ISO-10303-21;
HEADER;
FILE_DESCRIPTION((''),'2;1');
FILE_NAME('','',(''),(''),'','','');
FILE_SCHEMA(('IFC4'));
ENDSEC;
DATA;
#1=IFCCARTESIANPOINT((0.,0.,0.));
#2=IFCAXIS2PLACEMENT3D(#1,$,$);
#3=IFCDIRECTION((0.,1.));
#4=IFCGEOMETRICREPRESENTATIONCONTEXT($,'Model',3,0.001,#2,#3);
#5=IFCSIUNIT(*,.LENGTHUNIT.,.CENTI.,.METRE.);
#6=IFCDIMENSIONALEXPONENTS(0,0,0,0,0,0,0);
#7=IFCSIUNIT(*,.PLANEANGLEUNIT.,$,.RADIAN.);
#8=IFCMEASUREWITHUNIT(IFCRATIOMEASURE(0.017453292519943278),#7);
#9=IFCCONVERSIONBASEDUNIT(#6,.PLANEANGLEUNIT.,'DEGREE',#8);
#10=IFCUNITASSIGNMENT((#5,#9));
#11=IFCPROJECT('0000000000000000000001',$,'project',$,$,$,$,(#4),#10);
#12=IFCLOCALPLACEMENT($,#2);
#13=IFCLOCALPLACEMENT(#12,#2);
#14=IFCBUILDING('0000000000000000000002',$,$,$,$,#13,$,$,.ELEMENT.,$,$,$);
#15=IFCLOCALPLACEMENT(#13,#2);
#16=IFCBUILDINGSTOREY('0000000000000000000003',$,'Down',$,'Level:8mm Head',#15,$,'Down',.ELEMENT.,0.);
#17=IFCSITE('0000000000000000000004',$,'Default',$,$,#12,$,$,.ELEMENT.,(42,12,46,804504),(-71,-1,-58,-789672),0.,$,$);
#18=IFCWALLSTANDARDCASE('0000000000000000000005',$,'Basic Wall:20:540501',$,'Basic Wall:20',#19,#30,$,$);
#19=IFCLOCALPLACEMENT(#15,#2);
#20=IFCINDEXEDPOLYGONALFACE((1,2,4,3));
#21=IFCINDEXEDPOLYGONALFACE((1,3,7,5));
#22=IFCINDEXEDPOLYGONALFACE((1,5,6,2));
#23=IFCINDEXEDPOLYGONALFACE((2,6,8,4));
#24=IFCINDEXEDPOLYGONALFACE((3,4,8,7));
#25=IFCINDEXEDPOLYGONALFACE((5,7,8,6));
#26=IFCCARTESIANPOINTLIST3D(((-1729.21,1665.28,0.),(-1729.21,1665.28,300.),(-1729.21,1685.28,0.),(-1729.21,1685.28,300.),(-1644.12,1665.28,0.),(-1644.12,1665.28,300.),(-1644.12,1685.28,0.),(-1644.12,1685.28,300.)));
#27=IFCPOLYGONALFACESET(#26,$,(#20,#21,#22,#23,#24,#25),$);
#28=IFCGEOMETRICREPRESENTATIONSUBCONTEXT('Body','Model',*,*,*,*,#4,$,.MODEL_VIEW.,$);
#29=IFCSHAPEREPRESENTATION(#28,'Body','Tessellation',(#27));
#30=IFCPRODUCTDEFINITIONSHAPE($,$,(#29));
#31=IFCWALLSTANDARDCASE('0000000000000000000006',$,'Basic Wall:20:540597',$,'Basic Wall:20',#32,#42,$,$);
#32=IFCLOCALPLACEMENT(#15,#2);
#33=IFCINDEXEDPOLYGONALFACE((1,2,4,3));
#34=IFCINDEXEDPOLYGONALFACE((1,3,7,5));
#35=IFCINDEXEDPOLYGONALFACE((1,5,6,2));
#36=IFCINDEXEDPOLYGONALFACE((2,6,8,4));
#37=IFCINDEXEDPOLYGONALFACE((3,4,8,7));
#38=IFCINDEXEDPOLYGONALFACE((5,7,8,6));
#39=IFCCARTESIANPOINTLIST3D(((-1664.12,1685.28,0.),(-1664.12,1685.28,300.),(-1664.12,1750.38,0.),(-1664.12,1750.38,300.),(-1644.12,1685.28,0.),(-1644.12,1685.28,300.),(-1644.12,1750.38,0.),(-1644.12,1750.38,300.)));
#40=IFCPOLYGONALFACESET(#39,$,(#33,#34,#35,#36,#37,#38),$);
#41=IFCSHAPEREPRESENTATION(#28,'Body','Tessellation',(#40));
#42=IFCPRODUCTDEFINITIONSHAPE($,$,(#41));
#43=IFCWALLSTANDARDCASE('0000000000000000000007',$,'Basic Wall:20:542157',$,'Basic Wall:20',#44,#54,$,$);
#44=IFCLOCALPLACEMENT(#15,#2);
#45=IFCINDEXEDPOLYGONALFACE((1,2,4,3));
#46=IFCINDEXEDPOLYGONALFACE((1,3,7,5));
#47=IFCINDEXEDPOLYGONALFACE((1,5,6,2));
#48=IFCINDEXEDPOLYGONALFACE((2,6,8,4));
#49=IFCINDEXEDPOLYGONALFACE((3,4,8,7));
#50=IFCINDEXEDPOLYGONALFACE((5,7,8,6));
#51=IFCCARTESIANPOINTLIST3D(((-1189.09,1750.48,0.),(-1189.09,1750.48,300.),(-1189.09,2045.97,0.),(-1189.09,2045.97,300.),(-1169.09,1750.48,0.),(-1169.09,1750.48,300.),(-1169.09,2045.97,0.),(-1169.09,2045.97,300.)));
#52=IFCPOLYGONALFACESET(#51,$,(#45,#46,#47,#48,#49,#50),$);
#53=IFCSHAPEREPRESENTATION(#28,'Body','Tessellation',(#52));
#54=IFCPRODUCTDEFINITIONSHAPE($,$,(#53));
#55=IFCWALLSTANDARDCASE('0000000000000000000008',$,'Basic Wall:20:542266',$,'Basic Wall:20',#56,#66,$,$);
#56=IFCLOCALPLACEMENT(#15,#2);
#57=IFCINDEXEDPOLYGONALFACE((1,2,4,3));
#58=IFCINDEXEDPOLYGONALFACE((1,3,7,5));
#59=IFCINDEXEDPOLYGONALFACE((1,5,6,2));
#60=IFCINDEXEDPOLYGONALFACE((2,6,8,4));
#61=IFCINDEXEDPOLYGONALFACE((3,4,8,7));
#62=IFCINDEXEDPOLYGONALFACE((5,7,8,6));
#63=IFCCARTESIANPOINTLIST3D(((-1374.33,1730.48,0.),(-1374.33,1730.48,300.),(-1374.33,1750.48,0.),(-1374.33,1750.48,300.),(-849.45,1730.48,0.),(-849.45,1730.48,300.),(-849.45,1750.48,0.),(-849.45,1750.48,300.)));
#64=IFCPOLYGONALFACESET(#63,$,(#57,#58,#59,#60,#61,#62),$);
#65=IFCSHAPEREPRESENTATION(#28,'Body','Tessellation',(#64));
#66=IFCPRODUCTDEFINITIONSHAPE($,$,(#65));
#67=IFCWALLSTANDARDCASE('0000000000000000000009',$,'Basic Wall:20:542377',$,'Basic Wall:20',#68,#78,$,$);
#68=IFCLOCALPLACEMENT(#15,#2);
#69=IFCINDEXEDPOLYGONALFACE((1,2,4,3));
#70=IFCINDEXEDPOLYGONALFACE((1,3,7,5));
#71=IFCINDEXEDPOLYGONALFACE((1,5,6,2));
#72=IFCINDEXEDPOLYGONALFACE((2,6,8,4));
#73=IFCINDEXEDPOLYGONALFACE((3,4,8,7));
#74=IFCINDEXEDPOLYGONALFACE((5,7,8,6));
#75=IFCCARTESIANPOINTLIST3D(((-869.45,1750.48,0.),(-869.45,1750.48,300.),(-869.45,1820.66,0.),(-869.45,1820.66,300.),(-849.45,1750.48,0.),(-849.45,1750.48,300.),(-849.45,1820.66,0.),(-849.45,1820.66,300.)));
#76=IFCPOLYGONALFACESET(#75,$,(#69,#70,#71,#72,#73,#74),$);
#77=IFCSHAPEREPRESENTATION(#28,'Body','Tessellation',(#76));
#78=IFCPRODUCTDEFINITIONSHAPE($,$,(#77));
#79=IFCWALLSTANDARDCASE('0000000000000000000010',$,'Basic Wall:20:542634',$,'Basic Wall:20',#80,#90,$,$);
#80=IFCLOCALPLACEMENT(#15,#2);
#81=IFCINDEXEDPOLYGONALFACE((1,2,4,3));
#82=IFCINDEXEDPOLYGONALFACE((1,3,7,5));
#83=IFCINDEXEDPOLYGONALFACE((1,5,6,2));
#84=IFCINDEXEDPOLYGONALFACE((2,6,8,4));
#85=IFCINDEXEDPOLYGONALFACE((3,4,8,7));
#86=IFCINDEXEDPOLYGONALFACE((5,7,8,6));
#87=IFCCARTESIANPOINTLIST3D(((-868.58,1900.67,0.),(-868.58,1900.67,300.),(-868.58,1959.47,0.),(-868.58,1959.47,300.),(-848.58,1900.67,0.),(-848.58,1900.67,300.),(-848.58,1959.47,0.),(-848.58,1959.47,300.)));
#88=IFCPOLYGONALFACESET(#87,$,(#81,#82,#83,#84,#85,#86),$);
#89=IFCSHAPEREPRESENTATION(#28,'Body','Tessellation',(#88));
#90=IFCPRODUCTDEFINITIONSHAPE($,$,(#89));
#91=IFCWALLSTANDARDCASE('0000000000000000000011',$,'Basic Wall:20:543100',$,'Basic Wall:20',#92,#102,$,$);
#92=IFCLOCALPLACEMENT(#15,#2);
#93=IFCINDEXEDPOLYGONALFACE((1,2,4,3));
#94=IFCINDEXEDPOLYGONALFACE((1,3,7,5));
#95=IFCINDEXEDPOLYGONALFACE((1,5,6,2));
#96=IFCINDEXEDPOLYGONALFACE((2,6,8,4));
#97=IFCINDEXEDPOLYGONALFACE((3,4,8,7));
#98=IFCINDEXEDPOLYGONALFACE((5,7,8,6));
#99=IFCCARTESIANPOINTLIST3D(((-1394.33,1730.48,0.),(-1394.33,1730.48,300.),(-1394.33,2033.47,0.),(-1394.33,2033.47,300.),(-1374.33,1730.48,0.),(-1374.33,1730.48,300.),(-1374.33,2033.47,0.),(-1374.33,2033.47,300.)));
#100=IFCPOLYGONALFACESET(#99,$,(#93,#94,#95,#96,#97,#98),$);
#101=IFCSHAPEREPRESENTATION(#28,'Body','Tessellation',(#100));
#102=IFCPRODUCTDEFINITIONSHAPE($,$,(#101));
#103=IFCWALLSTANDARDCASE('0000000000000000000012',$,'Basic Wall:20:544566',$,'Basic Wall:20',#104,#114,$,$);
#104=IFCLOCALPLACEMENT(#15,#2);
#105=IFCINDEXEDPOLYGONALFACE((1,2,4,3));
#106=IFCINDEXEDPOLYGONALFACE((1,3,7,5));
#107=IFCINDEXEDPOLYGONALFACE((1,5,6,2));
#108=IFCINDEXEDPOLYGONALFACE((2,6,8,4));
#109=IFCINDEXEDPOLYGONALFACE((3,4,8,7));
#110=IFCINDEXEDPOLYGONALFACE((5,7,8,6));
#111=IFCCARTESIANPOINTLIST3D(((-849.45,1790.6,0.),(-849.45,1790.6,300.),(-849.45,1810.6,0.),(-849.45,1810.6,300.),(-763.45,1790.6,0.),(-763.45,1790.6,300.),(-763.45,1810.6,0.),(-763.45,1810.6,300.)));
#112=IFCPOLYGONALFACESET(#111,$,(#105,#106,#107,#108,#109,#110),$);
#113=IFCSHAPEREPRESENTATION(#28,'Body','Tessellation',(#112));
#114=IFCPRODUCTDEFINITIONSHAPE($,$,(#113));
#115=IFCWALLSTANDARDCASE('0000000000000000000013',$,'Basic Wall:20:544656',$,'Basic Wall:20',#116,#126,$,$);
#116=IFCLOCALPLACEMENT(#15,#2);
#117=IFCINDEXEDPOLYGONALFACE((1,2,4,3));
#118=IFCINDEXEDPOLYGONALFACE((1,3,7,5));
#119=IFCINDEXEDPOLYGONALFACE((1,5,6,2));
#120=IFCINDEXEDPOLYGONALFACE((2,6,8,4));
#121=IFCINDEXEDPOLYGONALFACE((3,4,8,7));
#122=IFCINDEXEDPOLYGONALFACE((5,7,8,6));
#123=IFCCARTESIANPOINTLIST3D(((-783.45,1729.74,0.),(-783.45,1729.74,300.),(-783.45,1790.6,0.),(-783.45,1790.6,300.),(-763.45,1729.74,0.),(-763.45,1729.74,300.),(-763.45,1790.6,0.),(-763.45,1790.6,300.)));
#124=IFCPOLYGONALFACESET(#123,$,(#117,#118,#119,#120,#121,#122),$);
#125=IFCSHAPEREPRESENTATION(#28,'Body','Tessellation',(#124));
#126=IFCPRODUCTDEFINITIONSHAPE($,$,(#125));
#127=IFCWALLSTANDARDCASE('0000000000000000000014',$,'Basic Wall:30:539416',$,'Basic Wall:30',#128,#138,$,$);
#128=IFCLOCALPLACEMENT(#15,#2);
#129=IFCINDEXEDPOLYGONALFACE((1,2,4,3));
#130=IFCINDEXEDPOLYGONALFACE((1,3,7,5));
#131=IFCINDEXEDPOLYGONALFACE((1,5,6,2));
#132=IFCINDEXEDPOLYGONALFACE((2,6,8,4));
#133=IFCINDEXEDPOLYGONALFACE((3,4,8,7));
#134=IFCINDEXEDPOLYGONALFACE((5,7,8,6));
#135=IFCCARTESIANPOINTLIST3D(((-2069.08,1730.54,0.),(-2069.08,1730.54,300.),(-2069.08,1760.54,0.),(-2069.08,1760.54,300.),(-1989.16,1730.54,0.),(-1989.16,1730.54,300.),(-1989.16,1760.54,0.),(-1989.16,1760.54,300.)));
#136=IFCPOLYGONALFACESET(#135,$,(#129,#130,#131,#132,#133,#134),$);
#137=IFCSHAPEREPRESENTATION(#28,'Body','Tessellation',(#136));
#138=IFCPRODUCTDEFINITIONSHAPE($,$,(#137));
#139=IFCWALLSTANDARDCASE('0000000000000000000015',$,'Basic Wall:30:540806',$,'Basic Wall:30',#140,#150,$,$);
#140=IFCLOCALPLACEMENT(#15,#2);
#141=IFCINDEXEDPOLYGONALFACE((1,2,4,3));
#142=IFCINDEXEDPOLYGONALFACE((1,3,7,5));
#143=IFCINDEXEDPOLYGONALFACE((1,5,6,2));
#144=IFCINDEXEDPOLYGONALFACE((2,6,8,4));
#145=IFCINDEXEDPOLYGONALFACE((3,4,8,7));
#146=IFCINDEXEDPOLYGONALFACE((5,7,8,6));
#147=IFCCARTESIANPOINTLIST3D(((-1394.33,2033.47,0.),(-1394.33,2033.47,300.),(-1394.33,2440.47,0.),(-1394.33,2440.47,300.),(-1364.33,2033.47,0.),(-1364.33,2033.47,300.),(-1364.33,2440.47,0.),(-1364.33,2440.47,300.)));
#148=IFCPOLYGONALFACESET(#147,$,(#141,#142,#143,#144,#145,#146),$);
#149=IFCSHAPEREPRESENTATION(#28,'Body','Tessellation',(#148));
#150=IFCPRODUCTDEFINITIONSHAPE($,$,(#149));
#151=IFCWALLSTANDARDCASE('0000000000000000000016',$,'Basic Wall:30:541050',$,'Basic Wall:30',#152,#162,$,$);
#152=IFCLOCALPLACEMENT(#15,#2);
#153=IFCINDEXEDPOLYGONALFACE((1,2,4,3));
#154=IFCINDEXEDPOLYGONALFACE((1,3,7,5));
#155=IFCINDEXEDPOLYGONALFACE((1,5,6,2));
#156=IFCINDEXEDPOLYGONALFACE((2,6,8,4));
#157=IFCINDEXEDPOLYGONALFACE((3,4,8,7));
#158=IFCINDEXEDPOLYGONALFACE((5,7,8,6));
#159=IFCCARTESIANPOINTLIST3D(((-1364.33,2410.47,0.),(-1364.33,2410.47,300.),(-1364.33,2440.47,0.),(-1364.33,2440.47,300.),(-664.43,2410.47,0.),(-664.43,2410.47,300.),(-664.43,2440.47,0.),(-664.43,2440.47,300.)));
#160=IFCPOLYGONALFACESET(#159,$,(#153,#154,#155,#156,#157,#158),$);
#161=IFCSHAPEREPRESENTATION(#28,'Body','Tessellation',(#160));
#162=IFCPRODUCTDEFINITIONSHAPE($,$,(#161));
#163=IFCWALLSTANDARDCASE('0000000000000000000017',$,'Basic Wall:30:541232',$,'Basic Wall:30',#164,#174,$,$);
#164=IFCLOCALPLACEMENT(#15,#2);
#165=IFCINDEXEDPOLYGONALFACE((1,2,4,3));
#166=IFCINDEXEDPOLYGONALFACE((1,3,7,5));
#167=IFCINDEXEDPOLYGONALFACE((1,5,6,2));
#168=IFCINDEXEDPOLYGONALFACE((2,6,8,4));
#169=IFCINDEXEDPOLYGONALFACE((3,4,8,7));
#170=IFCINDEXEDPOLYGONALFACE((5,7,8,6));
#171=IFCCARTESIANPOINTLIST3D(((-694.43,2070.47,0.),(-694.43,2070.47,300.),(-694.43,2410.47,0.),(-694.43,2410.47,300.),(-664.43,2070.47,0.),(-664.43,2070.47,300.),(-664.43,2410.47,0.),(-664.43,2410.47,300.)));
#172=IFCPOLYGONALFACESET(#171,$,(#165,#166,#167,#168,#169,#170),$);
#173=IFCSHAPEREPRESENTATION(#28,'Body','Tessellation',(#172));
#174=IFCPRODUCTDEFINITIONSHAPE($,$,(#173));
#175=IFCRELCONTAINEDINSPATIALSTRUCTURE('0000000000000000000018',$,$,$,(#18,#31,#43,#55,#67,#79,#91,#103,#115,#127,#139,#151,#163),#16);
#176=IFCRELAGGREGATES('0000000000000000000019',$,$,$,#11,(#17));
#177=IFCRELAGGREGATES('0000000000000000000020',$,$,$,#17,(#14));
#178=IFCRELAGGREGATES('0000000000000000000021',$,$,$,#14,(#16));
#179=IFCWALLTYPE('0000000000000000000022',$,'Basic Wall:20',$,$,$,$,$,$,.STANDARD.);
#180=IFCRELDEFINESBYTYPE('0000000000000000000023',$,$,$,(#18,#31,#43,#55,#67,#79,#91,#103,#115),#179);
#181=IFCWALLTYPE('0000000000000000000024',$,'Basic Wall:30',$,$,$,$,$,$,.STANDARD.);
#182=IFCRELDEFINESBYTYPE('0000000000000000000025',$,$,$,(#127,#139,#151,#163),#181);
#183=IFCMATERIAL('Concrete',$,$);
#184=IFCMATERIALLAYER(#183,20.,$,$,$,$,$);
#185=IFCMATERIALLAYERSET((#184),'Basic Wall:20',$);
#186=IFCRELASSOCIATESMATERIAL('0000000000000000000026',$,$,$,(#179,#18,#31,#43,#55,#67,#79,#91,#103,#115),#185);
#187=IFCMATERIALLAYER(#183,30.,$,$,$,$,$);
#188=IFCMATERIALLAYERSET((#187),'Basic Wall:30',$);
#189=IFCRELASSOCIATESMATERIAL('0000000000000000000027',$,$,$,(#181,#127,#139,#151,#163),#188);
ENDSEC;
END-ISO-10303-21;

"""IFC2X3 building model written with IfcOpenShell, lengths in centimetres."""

from ifc_helpers import new_model, entity, si_unit, converted_unit, direction, frame, frame_2d, origin, place, context, subcontext, project, spatial, rectangle, extrude, material, layer, layer_set, layer_usage, type_object, element, save


model = new_model("IFC2X3")

# Units and contexts
model_context = context("Model", 3, precision=0.001, world=origin(), true_north=direction((0.0, 1.0)))
body_context = subcontext(model_context, "Body", "Model", "MODEL_VIEW")
ifc_project = project(units=[si_unit("LENGTHUNIT", "METRE", prefix="CENTI"), converted_unit("PLANEANGLEUNIT", "DEGREE", entity("IfcRatioMeasure", 0.017453292519943278), si_unit("PLANEANGLEUNIT", "RADIAN"), dimensions=[0, 0, 0, 0, 0, 0, 0])], contexts=[model_context])

# Site, building, storey
site_placement = place(None, origin())
site = spatial("IfcSite", under=ifc_project, at=site_placement, Name="Default", CompositionType="ELEMENT", RefLatitude=(42, 12, 46, 804504), RefLongitude=(-71, -1, -58, -789672), RefElevation=0.0)
building_placement = place(site_placement, origin())
building = spatial("IfcBuilding", under=site, at=building_placement, CompositionType="ELEMENT")
storey_placement = place(building_placement, origin())
storey = spatial("IfcBuildingStorey", under=building, at=storey_placement, Name="Down", ObjectType="Level:8mm Head", LongName="Down", CompositionType="ELEMENT", Elevation=0.0)

# Shared definitions
ifc_material = material(Name="Concrete")

# Walls
ifc_layer_1 = layer(ifc_material, 20.0)
ifc_layer_set_1 = layer_set([ifc_layer_1], Name="Basic Wall:20")
wall_type_1 = type_object("IfcWallType", Name="Basic Wall:20", PredefinedType="STANDARD", material=ifc_layer_set_1)
ifc_layer_usage_1 = layer_usage(ifc_layer_set_1, "AXIS2", "POSITIVE", -10.0)
wall_1_placement = place(storey_placement, frame((-1729.21, 1675.28, 0.0)))
element("IfcWallStandardCase", 1, at=wall_1_placement, inside=storey, type_object=wall_type_1, material=ifc_layer_usage_1, Name="Basic Wall:20:540501", ObjectType="Basic Wall:20", context=body_context, shape_type="SweptSolid", body=[
    extrude(rectangle(XDim=85.1, YDim=20.0, at=frame_2d((42.55, 0.0), x_axis=(-1.0, 0.0))), origin(), (0.0, 0.0, 1.0), 300.0),
])
ifc_layer_usage_2 = layer_usage(ifc_layer_set_1, "AXIS2", "POSITIVE", -10.0)
wall_2_placement = place(storey_placement, frame((-1654.12, 1685.28, 0.0), z_axis=(0.0, 0.0, 1.0), x_axis=(0.0, 1.0, 0.0)))
element("IfcWallStandardCase", 2, at=wall_2_placement, inside=storey, type_object=wall_type_1, material=ifc_layer_usage_2, Name="Basic Wall:20:540597", ObjectType="Basic Wall:20", context=body_context, shape_type="SweptSolid", body=[
    extrude(rectangle(XDim=65.1, YDim=20.0, at=frame_2d((32.55, 0.0), x_axis=(-1.0, 0.0))), origin(), (0.0, 0.0, 1.0), 300.0),
])
ifc_layer_usage_3 = layer_usage(ifc_layer_set_1, "AXIS2", "NEGATIVE", 10.0)
wall_3_placement = place(storey_placement, frame((-1179.09, 2045.97, 0.0), z_axis=(0.0, 0.0, 1.0), x_axis=(0.0, -1.0, 0.0)))
element("IfcWallStandardCase", 3, at=wall_3_placement, inside=storey, type_object=wall_type_1, material=ifc_layer_usage_3, Name="Basic Wall:20:542157", ObjectType="Basic Wall:20", context=body_context, shape_type="SweptSolid", body=[
    extrude(rectangle(XDim=295.49, YDim=20.0, at=frame_2d((147.75, 0.0), x_axis=(-1.0, 0.0))), origin(), (0.0, 0.0, 1.0), 300.0),
])
ifc_layer_usage_4 = layer_usage(ifc_layer_set_1, "AXIS2", "POSITIVE", -10.0)
wall_4_placement = place(storey_placement, frame((-1374.33, 1740.48, 0.0)))
element("IfcWallStandardCase", 4, at=wall_4_placement, inside=storey, type_object=wall_type_1, material=ifc_layer_usage_4, Name="Basic Wall:20:542266", ObjectType="Basic Wall:20", context=body_context, shape_type="SweptSolid", body=[
    extrude(rectangle(XDim=524.88, YDim=20.0, at=frame_2d((262.44, 0.0), x_axis=(-1.0, 0.0))), origin(), (0.0, 0.0, 1.0), 300.0),
])
ifc_layer_usage_5 = layer_usage(ifc_layer_set_1, "AXIS2", "POSITIVE", -10.0)
wall_5_placement = place(storey_placement, frame((-859.45, 1750.48, 0.0), z_axis=(0.0, 0.0, 1.0), x_axis=(0.0, 1.0, 0.0)))
element("IfcWallStandardCase", 5, at=wall_5_placement, inside=storey, type_object=wall_type_1, material=ifc_layer_usage_5, Name="Basic Wall:20:542377", ObjectType="Basic Wall:20", context=body_context, shape_type="SweptSolid", body=[
    extrude(rectangle(XDim=70.18, YDim=20.0, at=frame_2d((35.09, 0.0), x_axis=(-1.0, 0.0))), origin(), (0.0, 0.0, 1.0), 300.0),
])
ifc_layer_usage_6 = layer_usage(ifc_layer_set_1, "AXIS2", "POSITIVE", -10.0)
wall_6_placement = place(storey_placement, frame((-858.58, 1900.67, 0.0), z_axis=(0.0, 0.0, 1.0), x_axis=(0.0, 1.0, 0.0)))
element("IfcWallStandardCase", 6, at=wall_6_placement, inside=storey, type_object=wall_type_1, material=ifc_layer_usage_6, Name="Basic Wall:20:542634", ObjectType="Basic Wall:20", context=body_context, shape_type="SweptSolid", body=[
    extrude(rectangle(XDim=58.79, YDim=20.0, at=frame_2d((29.4, 0.0), x_axis=(-1.0, 0.0))), origin(), (0.0, 0.0, 1.0), 300.0),
])
ifc_layer_usage_7 = layer_usage(ifc_layer_set_1, "AXIS2", "POSITIVE", -10.0)
wall_7_placement = place(storey_placement, frame((-1384.33, 2033.47, 0.0), z_axis=(0.0, 0.0, 1.0), x_axis=(0.0, -1.0, 0.0)))
element("IfcWallStandardCase", 7, at=wall_7_placement, inside=storey, type_object=wall_type_1, material=ifc_layer_usage_7, Name="Basic Wall:20:543100", ObjectType="Basic Wall:20", context=body_context, shape_type="SweptSolid", body=[
    extrude(rectangle(XDim=302.99, YDim=20.0, at=frame_2d((151.5, 0.0), x_axis=(-1.0, 0.0))), origin(), (0.0, 0.0, 1.0), 300.0),
])
ifc_layer_usage_8 = layer_usage(ifc_layer_set_1, "AXIS2", "POSITIVE", -10.0)
wall_8_placement = place(storey_placement, frame((-849.45, 1800.6, 0.0)))
element("IfcWallStandardCase", 8, at=wall_8_placement, inside=storey, type_object=wall_type_1, material=ifc_layer_usage_8, Name="Basic Wall:20:544566", ObjectType="Basic Wall:20", context=body_context, shape_type="SweptSolid", body=[
    extrude(rectangle(XDim=86.0, YDim=20.0, at=frame_2d((43.0, 0.0), x_axis=(-1.0, 0.0))), origin(), (0.0, 0.0, 1.0), 300.0),
])
ifc_layer_usage_9 = layer_usage(ifc_layer_set_1, "AXIS2", "NEGATIVE", 10.0)
wall_9_placement = place(storey_placement, frame((-773.45, 1790.6, 0.0), z_axis=(0.0, 0.0, 1.0), x_axis=(0.0, -1.0, 0.0)))
element("IfcWallStandardCase", 9, at=wall_9_placement, inside=storey, type_object=wall_type_1, material=ifc_layer_usage_9, Name="Basic Wall:20:544656", ObjectType="Basic Wall:20", context=body_context, shape_type="SweptSolid", body=[
    extrude(rectangle(XDim=60.85, YDim=20.0, at=frame_2d((30.43, 0.0), x_axis=(-1.0, 0.0))), origin(), (0.0, 0.0, 1.0), 300.0),
])
ifc_layer_2 = layer(ifc_material, 30.0)
ifc_layer_set_2 = layer_set([ifc_layer_2], Name="Basic Wall:30")
ifc_layer_usage_10 = layer_usage(ifc_layer_set_2, "AXIS2", "POSITIVE", -15.0)
wall_type_2 = type_object("IfcWallType", Name="Basic Wall:30", PredefinedType="STANDARD", material=ifc_layer_set_2)
wall_10_placement = place(storey_placement, frame((-1989.16, 1745.54, 0.0), z_axis=(0.0, 0.0, 1.0), x_axis=(-1.0, 0.0, 0.0)))
element("IfcWallStandardCase", 10, at=wall_10_placement, inside=storey, type_object=wall_type_2, material=ifc_layer_usage_10, Name="Basic Wall:30:539416", ObjectType="Basic Wall:30", context=body_context, shape_type="SweptSolid", body=[
    extrude(rectangle(XDim=79.92, YDim=30.0, at=frame_2d((39.96, 0.0), x_axis=(-1.0, 0.0))), origin(), (0.0, 0.0, 1.0), 300.0),
])
ifc_layer_usage_11 = layer_usage(ifc_layer_set_2, "AXIS2", "POSITIVE", -15.0)
wall_11_placement = place(storey_placement, frame((-1379.33, 2440.47, 0.0), z_axis=(0.0, 0.0, 1.0), x_axis=(0.0, -1.0, 0.0)))
element("IfcWallStandardCase", 11, at=wall_11_placement, inside=storey, type_object=wall_type_2, material=ifc_layer_usage_11, Name="Basic Wall:30:540806", ObjectType="Basic Wall:30", context=body_context, shape_type="SweptSolid", body=[
    extrude(rectangle(XDim=407.0, YDim=30.0, at=frame_2d((203.5, 0.0), x_axis=(-1.0, 0.0))), origin(), (0.0, 0.0, 1.0), 300.0),
])
ifc_layer_usage_12 = layer_usage(ifc_layer_set_2, "AXIS2", "NEGATIVE", 15.0)
wall_12_placement = place(storey_placement, frame((-1364.33, 2425.47, 0.0)))
element("IfcWallStandardCase", 12, at=wall_12_placement, inside=storey, type_object=wall_type_2, material=ifc_layer_usage_12, Name="Basic Wall:30:541050", ObjectType="Basic Wall:30", context=body_context, shape_type="SweptSolid", body=[
    extrude(rectangle(XDim=699.89, YDim=30.0, at=frame_2d((349.95, 0.0), x_axis=(-1.0, 0.0))), origin(), (0.0, 0.0, 1.0), 300.0),
])
ifc_layer_usage_13 = layer_usage(ifc_layer_set_2, "AXIS2", "NEGATIVE", 15.0)
wall_13_placement = place(storey_placement, frame((-679.43, 2410.47, 0.0), z_axis=(0.0, 0.0, 1.0), x_axis=(0.0, -1.0, 0.0)))
element("IfcWallStandardCase", 13, at=wall_13_placement, inside=storey, type_object=wall_type_2, material=ifc_layer_usage_13, Name="Basic Wall:30:541232", ObjectType="Basic Wall:30", context=body_context, shape_type="SweptSolid", body=[
    extrude(rectangle(XDim=340.01, YDim=30.0, at=frame_2d((170.0, 0.0), x_axis=(-1.0, 0.0))), origin(), (0.0, 0.0, 1.0), 300.0),
])

save(model, "model.ifc")
